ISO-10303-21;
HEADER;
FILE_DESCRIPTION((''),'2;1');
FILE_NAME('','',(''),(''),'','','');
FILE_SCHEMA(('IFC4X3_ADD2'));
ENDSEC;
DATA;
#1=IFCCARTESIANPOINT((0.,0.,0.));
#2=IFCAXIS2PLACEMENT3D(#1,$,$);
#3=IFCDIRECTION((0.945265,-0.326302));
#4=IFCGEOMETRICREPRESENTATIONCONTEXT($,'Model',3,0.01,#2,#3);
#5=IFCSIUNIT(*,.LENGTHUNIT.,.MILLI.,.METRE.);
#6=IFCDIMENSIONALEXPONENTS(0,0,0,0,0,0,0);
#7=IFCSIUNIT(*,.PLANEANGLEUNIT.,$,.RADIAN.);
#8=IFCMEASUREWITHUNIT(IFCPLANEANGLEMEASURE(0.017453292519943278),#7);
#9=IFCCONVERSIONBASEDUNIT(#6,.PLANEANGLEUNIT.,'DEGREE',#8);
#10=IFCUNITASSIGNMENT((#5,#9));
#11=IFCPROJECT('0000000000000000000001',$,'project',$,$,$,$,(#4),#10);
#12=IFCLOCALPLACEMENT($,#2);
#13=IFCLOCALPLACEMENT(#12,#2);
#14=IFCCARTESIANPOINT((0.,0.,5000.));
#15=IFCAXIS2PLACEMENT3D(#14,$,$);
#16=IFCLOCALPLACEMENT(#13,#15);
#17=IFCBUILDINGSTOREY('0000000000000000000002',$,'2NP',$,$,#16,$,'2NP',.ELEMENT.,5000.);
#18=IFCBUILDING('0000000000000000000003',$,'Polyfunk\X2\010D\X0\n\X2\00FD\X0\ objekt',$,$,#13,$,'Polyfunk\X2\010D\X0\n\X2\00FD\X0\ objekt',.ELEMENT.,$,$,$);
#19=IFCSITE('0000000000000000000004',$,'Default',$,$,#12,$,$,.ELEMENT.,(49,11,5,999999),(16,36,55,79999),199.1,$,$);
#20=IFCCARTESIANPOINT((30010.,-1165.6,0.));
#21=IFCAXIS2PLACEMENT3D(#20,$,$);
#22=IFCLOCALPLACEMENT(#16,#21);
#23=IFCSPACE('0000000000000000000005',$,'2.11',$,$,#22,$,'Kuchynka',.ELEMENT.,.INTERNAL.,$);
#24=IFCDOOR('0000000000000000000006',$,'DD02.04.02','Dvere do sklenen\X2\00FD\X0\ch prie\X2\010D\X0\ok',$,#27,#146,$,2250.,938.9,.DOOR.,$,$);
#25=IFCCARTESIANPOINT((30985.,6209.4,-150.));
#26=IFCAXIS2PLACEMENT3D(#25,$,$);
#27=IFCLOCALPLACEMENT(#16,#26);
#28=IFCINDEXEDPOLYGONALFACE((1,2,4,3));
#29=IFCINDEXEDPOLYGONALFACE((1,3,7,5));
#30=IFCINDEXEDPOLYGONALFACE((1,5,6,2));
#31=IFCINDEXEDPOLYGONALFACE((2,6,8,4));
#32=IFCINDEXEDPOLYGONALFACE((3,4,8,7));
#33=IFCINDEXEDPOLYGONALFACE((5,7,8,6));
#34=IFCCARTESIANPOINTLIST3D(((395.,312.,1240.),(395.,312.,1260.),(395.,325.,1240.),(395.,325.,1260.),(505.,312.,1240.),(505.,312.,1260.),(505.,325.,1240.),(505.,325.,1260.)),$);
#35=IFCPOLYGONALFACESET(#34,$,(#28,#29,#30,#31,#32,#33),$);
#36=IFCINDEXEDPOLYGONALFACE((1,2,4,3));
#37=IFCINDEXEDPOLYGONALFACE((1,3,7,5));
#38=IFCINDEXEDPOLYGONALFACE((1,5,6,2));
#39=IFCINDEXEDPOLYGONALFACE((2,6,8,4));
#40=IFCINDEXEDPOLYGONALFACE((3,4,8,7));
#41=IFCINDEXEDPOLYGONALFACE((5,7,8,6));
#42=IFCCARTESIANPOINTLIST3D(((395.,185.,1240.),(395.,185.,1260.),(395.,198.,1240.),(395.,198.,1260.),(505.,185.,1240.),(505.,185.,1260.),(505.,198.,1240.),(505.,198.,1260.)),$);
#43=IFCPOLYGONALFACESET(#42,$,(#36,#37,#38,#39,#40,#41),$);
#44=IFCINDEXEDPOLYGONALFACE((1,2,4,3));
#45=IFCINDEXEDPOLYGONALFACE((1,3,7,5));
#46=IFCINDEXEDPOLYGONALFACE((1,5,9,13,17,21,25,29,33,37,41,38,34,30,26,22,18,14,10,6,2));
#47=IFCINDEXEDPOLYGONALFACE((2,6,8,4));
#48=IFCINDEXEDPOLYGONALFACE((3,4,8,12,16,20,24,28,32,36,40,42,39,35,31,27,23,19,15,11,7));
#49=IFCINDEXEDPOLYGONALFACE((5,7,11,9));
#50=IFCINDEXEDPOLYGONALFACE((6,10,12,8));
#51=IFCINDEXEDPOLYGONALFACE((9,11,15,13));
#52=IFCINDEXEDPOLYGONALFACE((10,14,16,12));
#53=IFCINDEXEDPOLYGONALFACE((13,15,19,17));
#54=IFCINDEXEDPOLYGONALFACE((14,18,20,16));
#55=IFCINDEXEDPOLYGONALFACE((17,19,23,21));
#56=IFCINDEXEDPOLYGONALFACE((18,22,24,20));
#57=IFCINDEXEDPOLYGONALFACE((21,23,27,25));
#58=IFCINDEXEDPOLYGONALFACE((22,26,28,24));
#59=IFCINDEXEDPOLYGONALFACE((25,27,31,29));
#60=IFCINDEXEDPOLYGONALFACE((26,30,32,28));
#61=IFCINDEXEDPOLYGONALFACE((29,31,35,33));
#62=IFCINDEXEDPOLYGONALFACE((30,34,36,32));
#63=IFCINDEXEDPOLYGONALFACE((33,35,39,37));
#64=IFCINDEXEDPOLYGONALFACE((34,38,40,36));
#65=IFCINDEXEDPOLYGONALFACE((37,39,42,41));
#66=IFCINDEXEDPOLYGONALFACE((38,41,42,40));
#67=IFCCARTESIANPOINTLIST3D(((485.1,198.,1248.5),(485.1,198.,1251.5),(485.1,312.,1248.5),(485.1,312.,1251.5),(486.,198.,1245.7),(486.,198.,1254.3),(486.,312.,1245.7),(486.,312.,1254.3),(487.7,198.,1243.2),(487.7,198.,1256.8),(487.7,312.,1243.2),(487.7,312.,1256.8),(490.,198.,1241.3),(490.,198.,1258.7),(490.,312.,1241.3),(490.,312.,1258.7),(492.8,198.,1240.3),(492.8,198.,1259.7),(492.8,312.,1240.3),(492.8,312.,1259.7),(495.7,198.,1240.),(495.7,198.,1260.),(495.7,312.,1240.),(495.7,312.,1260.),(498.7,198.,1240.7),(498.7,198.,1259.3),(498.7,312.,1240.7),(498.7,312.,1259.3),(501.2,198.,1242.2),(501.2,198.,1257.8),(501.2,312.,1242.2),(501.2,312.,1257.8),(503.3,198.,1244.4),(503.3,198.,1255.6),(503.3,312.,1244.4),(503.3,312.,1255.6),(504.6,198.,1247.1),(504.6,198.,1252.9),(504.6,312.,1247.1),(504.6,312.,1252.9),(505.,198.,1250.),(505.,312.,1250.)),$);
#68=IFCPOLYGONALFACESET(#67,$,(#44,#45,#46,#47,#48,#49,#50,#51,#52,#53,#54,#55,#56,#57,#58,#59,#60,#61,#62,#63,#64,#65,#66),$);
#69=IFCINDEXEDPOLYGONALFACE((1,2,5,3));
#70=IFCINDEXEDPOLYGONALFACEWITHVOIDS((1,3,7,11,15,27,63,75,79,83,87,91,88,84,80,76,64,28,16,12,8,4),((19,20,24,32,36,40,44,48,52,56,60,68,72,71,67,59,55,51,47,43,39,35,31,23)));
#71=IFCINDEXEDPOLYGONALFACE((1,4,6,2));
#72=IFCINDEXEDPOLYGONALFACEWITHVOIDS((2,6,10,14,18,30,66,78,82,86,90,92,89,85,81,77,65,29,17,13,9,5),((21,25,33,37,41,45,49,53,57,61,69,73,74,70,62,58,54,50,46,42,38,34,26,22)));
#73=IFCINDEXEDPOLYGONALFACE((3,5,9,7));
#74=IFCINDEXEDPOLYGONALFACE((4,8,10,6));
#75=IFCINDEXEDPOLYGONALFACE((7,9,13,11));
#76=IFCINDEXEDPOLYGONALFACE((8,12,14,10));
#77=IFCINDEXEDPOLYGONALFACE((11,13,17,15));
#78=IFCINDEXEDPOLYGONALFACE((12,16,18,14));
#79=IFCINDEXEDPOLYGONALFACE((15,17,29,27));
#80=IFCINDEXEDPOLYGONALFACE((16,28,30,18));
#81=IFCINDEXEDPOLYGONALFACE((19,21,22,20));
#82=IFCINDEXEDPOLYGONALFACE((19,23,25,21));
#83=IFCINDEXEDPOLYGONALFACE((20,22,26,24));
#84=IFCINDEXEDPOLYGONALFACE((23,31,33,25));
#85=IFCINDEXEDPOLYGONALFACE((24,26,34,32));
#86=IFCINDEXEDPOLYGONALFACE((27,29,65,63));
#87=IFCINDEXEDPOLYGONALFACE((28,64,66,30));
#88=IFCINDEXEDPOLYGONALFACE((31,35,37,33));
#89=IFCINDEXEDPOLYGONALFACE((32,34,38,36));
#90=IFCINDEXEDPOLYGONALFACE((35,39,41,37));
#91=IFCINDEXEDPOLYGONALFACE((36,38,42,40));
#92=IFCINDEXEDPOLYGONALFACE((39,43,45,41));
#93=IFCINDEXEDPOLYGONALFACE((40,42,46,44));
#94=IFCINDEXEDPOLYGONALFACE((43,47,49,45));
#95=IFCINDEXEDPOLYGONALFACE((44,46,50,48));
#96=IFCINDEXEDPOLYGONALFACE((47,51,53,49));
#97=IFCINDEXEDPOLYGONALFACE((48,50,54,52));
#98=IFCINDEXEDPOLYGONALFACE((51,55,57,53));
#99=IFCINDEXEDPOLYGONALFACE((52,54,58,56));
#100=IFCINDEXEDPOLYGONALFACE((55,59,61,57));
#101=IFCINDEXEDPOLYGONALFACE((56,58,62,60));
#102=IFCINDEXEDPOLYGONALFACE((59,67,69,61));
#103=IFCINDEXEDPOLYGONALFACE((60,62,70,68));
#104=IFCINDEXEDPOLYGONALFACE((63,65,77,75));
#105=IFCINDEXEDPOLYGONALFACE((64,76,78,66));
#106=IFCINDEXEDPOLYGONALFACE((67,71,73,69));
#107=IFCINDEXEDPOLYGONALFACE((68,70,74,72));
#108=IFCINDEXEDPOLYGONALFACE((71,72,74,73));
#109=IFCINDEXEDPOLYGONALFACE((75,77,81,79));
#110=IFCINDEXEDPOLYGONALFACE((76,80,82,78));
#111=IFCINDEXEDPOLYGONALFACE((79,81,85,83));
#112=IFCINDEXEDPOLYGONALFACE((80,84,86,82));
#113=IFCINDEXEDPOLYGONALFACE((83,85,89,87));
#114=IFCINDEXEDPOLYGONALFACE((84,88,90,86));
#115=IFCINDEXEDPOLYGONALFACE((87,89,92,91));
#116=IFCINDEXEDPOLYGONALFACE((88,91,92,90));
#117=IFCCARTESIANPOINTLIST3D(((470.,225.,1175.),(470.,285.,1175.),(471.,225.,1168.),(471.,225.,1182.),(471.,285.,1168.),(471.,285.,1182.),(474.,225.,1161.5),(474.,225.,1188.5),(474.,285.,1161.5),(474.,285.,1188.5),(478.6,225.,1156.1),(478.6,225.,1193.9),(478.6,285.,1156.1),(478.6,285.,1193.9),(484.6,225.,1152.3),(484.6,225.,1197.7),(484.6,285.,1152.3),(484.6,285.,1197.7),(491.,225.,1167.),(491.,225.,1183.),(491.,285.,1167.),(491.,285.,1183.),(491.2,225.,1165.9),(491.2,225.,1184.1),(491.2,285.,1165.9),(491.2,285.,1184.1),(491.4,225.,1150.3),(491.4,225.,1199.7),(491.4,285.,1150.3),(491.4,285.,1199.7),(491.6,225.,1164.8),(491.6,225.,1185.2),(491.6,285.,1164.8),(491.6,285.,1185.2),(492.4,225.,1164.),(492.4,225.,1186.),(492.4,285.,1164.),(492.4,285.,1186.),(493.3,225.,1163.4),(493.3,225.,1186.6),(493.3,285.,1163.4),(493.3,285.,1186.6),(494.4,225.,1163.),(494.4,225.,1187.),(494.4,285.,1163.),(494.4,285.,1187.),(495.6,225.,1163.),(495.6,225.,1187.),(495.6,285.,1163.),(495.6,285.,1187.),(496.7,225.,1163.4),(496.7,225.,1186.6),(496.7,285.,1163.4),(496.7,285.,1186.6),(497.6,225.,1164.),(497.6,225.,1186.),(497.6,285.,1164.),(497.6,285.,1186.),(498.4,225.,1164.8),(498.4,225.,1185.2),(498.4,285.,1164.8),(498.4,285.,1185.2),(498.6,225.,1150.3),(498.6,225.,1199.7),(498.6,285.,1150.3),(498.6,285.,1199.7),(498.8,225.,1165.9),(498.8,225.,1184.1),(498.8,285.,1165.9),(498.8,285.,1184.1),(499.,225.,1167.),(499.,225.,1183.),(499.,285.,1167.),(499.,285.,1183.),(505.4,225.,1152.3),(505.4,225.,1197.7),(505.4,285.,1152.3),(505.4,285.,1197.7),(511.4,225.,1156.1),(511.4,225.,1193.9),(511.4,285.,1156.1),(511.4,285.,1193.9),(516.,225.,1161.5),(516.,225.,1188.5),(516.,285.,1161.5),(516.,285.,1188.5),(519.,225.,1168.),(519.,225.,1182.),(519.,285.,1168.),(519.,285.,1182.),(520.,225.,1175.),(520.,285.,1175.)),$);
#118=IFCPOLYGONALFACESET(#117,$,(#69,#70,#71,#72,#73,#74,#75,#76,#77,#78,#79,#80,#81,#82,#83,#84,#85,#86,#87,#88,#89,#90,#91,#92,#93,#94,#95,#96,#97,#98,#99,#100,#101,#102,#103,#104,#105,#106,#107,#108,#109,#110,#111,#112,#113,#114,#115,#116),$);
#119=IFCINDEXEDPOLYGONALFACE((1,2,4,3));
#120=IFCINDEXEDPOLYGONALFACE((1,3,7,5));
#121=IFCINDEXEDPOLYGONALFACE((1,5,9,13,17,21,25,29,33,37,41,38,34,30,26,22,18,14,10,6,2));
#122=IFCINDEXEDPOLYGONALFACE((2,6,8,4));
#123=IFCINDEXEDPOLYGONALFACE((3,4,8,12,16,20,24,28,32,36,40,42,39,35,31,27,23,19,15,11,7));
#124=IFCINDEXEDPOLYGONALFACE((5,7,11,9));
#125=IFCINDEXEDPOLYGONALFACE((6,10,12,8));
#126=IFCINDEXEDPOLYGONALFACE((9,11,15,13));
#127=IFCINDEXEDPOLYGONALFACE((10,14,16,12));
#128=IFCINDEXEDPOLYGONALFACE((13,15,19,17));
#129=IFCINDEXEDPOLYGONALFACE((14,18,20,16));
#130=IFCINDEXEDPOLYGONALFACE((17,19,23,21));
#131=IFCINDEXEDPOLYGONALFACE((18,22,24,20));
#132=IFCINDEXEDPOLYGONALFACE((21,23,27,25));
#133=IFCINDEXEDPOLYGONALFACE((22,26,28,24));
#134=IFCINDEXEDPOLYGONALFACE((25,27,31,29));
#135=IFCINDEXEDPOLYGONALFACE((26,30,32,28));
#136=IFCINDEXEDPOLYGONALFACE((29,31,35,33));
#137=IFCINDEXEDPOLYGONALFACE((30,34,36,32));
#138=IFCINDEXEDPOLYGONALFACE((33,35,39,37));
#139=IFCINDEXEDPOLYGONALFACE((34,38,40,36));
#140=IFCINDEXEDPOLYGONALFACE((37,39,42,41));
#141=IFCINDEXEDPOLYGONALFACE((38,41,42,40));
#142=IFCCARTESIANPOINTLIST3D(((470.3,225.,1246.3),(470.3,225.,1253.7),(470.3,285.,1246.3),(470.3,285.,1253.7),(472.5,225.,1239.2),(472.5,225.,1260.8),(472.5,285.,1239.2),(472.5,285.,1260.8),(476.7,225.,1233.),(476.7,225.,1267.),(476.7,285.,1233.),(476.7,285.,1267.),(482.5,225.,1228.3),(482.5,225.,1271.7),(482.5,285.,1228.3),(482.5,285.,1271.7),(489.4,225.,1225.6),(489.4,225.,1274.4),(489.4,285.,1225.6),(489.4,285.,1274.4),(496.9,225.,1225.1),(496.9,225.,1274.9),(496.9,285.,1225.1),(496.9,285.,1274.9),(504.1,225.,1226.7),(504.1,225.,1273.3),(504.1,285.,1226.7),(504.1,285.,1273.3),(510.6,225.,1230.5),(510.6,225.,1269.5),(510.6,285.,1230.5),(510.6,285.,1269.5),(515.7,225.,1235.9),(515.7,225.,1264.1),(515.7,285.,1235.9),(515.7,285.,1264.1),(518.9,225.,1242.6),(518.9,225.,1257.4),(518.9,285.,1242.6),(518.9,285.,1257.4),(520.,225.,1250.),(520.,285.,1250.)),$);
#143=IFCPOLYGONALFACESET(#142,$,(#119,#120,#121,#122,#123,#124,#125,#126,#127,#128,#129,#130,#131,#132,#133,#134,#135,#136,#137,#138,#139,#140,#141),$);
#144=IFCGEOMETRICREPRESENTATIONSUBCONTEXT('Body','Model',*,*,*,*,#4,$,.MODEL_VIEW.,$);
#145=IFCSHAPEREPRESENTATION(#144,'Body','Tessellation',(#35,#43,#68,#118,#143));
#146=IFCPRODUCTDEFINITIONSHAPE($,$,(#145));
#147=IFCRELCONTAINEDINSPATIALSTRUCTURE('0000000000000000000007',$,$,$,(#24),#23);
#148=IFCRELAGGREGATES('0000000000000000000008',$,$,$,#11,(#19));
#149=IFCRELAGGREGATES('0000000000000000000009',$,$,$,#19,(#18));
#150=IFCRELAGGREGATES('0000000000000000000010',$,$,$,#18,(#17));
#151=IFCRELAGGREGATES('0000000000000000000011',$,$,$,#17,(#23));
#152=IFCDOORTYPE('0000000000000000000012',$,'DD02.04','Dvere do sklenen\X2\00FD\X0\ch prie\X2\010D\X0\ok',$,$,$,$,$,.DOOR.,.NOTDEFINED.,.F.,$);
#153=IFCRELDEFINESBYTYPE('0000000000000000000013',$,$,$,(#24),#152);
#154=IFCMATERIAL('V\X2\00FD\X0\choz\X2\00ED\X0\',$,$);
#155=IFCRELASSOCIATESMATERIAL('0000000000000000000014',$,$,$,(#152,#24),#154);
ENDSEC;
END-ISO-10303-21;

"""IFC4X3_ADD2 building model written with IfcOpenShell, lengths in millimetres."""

from ifc_helpers import new_model, entity, si_unit, converted_unit, direction, frame, frame_2d, origin, origin_2d_with_axis, place, context, subcontext, project, spatial, polyline, circle_curve, parameter, trimmed, segment, composite_curve, rectangle, circle, outline, extrude, source, transform, mapped, material, type_object, type_shapes, element, save


model = new_model("IFC4X3_ADD2")

# Units and contexts
model_context = context("Model", 3, precision=0.01, world=origin(), true_north=direction((0.945265, -0.326302)))
body_context = subcontext(model_context, "Body", "Model", "MODEL_VIEW")
ifc_project = project(units=[si_unit("LENGTHUNIT", "METRE", prefix="MILLI"), converted_unit("PLANEANGLEUNIT", "DEGREE", entity("IfcPlaneAngleMeasure", 0.017453292519943278), si_unit("PLANEANGLEUNIT", "RADIAN"), dimensions=[0, 0, 0, 0, 0, 0, 0])], contexts=[model_context])

# Site, building, storey
site_placement = place(None, origin())
site = spatial("IfcSite", under=ifc_project, at=site_placement, Name="Default", CompositionType="ELEMENT", RefLatitude=(49, 11, 5, 999999), RefLongitude=(16, 36, 55, 79999), RefElevation=199.1)
building_placement = place(site_placement, origin())
building = spatial("IfcBuilding", under=site, at=building_placement, Name="Polyfunkčný objekt", LongName="Polyfunkčný objekt", CompositionType="ELEMENT")
storey_placement = place(building_placement, frame((0.0, 0.0, 5000.0)))
storey = spatial("IfcBuildingStorey", under=building, at=storey_placement, Name="2NP", LongName="2NP", CompositionType="ELEMENT", Elevation=5000.0)

# Shared definitions
space_placement = place(storey_placement, frame((30010.0, -1165.6, 0.0)))
space = spatial("IfcSpace", under=storey, at=space_placement, Name="2.11", LongName="Kuchynka", CompositionType="ELEMENT", PredefinedType="INTERNAL")

# Door
ifc_material_1 = material(Name="Výchozí")
door_type = type_object("IfcDoorType", Name="DD02.04", Description="Dvere do sklenených priečok", OperationType="NOTDEFINED", ParameterTakesPrecedence=False, PredefinedType="DOOR", material=ifc_material_1)
shared_shape_1 = source(origin(), body_context, "Body", "SweptSolid", [
    extrude(rectangle(XDim=13.0, YDim=110.0, at=frame_2d((0.0, 0.0), x_axis=(1.0, 0.0))), frame((450.0, 318.5, 1240.0), z_axis=(0.0, 0.0, 1.0), x_axis=(0.0, 1.0, 0.0)), (0.0, 0.0, 1.0), 20.0),
    extrude(rectangle(XDim=13.0, YDim=110.0, at=frame_2d((0.0, 0.0), x_axis=(1.0, 0.0))), frame((450.0, 191.5, 1240.0), z_axis=(0.0, 0.0, 1.0), x_axis=(0.0, -1.0, 0.0)), (0.0, 0.0, 1.0), 20.0),
    extrude(circle(Radius=10.0, at=origin_2d_with_axis()), frame((495.0, 312.0, 1250.0), z_axis=(0.0, -1.0, 0.0), x_axis=(1.0, 0.0, 0.0)), (0.0, 0.0, 1.0), 114.0),
    extrude(outline(composite_curve([segment(trimmed(circle_curve(origin_2d_with_axis(), 25.0), [parameter(180.0)], [parameter(360.0)], True, "PARAMETER"), True, "CONTINUOUS"), segment(trimmed(circle_curve(origin_2d_with_axis(), 25.0), [parameter(0.0)], [parameter(180.0)], True, "PARAMETER"), True, "CONTINUOUS")], self_intersect=False), holes=[composite_curve([segment(trimmed(circle_curve(frame_2d((0.0, 8.0), x_axis=(1.0, 0.0)), 4.0), [parameter(0.0)], [parameter(180.0)], True, "PARAMETER"), False, "CONTINUOUS"), segment(polyline([(4.0, 8.0), (4.0, -8.0)]), True, "CONTINUOUS"), segment(trimmed(circle_curve(frame_2d((0.0, -8.0), x_axis=(1.0, 0.0)), 4.0), [parameter(180.0)], [parameter(0.0)], True, "PARAMETER"), False, "CONTINUOUS"), segment(polyline([(-4.0, -8.0), (-4.0, 8.0)]), True, "CONTINUOUS")], self_intersect=False)]), frame((495.0, 285.0, 1175.0), z_axis=(0.0, -1.0, 0.0), x_axis=(1.0, 0.0, 0.0)), (0.0, 0.0, 1.0), 60.0),
    extrude(circle(Radius=25.0, at=frame_2d((0.0, 0.0), x_axis=(1.0, 0.0))), frame((495.0, 285.0, 1250.0), z_axis=(0.0, -1.0, 0.0), x_axis=(1.0, 0.0, 0.0)), (0.0, 0.0, 1.0), 60.0),
])
type_shapes(door_type, [shared_shape_1])
door_placement = place(storey_placement, frame((30985.0, 6209.4, -150.0)))
element("IfcDoor", 1, at=door_placement, inside=space, type_object=door_type, material=ifc_material_1, Name="DD02.04.02", Description="Dvere do sklenených priečok", OverallHeight=2250.0, OverallWidth=938.9, PredefinedType="DOOR", context=body_context, shape_type="MappedRepresentation", body=[
    mapped(shared_shape_1, transform((0.0, 0.0, 0.0), scale=1.0)),
])

save(model, "model.ifc")
